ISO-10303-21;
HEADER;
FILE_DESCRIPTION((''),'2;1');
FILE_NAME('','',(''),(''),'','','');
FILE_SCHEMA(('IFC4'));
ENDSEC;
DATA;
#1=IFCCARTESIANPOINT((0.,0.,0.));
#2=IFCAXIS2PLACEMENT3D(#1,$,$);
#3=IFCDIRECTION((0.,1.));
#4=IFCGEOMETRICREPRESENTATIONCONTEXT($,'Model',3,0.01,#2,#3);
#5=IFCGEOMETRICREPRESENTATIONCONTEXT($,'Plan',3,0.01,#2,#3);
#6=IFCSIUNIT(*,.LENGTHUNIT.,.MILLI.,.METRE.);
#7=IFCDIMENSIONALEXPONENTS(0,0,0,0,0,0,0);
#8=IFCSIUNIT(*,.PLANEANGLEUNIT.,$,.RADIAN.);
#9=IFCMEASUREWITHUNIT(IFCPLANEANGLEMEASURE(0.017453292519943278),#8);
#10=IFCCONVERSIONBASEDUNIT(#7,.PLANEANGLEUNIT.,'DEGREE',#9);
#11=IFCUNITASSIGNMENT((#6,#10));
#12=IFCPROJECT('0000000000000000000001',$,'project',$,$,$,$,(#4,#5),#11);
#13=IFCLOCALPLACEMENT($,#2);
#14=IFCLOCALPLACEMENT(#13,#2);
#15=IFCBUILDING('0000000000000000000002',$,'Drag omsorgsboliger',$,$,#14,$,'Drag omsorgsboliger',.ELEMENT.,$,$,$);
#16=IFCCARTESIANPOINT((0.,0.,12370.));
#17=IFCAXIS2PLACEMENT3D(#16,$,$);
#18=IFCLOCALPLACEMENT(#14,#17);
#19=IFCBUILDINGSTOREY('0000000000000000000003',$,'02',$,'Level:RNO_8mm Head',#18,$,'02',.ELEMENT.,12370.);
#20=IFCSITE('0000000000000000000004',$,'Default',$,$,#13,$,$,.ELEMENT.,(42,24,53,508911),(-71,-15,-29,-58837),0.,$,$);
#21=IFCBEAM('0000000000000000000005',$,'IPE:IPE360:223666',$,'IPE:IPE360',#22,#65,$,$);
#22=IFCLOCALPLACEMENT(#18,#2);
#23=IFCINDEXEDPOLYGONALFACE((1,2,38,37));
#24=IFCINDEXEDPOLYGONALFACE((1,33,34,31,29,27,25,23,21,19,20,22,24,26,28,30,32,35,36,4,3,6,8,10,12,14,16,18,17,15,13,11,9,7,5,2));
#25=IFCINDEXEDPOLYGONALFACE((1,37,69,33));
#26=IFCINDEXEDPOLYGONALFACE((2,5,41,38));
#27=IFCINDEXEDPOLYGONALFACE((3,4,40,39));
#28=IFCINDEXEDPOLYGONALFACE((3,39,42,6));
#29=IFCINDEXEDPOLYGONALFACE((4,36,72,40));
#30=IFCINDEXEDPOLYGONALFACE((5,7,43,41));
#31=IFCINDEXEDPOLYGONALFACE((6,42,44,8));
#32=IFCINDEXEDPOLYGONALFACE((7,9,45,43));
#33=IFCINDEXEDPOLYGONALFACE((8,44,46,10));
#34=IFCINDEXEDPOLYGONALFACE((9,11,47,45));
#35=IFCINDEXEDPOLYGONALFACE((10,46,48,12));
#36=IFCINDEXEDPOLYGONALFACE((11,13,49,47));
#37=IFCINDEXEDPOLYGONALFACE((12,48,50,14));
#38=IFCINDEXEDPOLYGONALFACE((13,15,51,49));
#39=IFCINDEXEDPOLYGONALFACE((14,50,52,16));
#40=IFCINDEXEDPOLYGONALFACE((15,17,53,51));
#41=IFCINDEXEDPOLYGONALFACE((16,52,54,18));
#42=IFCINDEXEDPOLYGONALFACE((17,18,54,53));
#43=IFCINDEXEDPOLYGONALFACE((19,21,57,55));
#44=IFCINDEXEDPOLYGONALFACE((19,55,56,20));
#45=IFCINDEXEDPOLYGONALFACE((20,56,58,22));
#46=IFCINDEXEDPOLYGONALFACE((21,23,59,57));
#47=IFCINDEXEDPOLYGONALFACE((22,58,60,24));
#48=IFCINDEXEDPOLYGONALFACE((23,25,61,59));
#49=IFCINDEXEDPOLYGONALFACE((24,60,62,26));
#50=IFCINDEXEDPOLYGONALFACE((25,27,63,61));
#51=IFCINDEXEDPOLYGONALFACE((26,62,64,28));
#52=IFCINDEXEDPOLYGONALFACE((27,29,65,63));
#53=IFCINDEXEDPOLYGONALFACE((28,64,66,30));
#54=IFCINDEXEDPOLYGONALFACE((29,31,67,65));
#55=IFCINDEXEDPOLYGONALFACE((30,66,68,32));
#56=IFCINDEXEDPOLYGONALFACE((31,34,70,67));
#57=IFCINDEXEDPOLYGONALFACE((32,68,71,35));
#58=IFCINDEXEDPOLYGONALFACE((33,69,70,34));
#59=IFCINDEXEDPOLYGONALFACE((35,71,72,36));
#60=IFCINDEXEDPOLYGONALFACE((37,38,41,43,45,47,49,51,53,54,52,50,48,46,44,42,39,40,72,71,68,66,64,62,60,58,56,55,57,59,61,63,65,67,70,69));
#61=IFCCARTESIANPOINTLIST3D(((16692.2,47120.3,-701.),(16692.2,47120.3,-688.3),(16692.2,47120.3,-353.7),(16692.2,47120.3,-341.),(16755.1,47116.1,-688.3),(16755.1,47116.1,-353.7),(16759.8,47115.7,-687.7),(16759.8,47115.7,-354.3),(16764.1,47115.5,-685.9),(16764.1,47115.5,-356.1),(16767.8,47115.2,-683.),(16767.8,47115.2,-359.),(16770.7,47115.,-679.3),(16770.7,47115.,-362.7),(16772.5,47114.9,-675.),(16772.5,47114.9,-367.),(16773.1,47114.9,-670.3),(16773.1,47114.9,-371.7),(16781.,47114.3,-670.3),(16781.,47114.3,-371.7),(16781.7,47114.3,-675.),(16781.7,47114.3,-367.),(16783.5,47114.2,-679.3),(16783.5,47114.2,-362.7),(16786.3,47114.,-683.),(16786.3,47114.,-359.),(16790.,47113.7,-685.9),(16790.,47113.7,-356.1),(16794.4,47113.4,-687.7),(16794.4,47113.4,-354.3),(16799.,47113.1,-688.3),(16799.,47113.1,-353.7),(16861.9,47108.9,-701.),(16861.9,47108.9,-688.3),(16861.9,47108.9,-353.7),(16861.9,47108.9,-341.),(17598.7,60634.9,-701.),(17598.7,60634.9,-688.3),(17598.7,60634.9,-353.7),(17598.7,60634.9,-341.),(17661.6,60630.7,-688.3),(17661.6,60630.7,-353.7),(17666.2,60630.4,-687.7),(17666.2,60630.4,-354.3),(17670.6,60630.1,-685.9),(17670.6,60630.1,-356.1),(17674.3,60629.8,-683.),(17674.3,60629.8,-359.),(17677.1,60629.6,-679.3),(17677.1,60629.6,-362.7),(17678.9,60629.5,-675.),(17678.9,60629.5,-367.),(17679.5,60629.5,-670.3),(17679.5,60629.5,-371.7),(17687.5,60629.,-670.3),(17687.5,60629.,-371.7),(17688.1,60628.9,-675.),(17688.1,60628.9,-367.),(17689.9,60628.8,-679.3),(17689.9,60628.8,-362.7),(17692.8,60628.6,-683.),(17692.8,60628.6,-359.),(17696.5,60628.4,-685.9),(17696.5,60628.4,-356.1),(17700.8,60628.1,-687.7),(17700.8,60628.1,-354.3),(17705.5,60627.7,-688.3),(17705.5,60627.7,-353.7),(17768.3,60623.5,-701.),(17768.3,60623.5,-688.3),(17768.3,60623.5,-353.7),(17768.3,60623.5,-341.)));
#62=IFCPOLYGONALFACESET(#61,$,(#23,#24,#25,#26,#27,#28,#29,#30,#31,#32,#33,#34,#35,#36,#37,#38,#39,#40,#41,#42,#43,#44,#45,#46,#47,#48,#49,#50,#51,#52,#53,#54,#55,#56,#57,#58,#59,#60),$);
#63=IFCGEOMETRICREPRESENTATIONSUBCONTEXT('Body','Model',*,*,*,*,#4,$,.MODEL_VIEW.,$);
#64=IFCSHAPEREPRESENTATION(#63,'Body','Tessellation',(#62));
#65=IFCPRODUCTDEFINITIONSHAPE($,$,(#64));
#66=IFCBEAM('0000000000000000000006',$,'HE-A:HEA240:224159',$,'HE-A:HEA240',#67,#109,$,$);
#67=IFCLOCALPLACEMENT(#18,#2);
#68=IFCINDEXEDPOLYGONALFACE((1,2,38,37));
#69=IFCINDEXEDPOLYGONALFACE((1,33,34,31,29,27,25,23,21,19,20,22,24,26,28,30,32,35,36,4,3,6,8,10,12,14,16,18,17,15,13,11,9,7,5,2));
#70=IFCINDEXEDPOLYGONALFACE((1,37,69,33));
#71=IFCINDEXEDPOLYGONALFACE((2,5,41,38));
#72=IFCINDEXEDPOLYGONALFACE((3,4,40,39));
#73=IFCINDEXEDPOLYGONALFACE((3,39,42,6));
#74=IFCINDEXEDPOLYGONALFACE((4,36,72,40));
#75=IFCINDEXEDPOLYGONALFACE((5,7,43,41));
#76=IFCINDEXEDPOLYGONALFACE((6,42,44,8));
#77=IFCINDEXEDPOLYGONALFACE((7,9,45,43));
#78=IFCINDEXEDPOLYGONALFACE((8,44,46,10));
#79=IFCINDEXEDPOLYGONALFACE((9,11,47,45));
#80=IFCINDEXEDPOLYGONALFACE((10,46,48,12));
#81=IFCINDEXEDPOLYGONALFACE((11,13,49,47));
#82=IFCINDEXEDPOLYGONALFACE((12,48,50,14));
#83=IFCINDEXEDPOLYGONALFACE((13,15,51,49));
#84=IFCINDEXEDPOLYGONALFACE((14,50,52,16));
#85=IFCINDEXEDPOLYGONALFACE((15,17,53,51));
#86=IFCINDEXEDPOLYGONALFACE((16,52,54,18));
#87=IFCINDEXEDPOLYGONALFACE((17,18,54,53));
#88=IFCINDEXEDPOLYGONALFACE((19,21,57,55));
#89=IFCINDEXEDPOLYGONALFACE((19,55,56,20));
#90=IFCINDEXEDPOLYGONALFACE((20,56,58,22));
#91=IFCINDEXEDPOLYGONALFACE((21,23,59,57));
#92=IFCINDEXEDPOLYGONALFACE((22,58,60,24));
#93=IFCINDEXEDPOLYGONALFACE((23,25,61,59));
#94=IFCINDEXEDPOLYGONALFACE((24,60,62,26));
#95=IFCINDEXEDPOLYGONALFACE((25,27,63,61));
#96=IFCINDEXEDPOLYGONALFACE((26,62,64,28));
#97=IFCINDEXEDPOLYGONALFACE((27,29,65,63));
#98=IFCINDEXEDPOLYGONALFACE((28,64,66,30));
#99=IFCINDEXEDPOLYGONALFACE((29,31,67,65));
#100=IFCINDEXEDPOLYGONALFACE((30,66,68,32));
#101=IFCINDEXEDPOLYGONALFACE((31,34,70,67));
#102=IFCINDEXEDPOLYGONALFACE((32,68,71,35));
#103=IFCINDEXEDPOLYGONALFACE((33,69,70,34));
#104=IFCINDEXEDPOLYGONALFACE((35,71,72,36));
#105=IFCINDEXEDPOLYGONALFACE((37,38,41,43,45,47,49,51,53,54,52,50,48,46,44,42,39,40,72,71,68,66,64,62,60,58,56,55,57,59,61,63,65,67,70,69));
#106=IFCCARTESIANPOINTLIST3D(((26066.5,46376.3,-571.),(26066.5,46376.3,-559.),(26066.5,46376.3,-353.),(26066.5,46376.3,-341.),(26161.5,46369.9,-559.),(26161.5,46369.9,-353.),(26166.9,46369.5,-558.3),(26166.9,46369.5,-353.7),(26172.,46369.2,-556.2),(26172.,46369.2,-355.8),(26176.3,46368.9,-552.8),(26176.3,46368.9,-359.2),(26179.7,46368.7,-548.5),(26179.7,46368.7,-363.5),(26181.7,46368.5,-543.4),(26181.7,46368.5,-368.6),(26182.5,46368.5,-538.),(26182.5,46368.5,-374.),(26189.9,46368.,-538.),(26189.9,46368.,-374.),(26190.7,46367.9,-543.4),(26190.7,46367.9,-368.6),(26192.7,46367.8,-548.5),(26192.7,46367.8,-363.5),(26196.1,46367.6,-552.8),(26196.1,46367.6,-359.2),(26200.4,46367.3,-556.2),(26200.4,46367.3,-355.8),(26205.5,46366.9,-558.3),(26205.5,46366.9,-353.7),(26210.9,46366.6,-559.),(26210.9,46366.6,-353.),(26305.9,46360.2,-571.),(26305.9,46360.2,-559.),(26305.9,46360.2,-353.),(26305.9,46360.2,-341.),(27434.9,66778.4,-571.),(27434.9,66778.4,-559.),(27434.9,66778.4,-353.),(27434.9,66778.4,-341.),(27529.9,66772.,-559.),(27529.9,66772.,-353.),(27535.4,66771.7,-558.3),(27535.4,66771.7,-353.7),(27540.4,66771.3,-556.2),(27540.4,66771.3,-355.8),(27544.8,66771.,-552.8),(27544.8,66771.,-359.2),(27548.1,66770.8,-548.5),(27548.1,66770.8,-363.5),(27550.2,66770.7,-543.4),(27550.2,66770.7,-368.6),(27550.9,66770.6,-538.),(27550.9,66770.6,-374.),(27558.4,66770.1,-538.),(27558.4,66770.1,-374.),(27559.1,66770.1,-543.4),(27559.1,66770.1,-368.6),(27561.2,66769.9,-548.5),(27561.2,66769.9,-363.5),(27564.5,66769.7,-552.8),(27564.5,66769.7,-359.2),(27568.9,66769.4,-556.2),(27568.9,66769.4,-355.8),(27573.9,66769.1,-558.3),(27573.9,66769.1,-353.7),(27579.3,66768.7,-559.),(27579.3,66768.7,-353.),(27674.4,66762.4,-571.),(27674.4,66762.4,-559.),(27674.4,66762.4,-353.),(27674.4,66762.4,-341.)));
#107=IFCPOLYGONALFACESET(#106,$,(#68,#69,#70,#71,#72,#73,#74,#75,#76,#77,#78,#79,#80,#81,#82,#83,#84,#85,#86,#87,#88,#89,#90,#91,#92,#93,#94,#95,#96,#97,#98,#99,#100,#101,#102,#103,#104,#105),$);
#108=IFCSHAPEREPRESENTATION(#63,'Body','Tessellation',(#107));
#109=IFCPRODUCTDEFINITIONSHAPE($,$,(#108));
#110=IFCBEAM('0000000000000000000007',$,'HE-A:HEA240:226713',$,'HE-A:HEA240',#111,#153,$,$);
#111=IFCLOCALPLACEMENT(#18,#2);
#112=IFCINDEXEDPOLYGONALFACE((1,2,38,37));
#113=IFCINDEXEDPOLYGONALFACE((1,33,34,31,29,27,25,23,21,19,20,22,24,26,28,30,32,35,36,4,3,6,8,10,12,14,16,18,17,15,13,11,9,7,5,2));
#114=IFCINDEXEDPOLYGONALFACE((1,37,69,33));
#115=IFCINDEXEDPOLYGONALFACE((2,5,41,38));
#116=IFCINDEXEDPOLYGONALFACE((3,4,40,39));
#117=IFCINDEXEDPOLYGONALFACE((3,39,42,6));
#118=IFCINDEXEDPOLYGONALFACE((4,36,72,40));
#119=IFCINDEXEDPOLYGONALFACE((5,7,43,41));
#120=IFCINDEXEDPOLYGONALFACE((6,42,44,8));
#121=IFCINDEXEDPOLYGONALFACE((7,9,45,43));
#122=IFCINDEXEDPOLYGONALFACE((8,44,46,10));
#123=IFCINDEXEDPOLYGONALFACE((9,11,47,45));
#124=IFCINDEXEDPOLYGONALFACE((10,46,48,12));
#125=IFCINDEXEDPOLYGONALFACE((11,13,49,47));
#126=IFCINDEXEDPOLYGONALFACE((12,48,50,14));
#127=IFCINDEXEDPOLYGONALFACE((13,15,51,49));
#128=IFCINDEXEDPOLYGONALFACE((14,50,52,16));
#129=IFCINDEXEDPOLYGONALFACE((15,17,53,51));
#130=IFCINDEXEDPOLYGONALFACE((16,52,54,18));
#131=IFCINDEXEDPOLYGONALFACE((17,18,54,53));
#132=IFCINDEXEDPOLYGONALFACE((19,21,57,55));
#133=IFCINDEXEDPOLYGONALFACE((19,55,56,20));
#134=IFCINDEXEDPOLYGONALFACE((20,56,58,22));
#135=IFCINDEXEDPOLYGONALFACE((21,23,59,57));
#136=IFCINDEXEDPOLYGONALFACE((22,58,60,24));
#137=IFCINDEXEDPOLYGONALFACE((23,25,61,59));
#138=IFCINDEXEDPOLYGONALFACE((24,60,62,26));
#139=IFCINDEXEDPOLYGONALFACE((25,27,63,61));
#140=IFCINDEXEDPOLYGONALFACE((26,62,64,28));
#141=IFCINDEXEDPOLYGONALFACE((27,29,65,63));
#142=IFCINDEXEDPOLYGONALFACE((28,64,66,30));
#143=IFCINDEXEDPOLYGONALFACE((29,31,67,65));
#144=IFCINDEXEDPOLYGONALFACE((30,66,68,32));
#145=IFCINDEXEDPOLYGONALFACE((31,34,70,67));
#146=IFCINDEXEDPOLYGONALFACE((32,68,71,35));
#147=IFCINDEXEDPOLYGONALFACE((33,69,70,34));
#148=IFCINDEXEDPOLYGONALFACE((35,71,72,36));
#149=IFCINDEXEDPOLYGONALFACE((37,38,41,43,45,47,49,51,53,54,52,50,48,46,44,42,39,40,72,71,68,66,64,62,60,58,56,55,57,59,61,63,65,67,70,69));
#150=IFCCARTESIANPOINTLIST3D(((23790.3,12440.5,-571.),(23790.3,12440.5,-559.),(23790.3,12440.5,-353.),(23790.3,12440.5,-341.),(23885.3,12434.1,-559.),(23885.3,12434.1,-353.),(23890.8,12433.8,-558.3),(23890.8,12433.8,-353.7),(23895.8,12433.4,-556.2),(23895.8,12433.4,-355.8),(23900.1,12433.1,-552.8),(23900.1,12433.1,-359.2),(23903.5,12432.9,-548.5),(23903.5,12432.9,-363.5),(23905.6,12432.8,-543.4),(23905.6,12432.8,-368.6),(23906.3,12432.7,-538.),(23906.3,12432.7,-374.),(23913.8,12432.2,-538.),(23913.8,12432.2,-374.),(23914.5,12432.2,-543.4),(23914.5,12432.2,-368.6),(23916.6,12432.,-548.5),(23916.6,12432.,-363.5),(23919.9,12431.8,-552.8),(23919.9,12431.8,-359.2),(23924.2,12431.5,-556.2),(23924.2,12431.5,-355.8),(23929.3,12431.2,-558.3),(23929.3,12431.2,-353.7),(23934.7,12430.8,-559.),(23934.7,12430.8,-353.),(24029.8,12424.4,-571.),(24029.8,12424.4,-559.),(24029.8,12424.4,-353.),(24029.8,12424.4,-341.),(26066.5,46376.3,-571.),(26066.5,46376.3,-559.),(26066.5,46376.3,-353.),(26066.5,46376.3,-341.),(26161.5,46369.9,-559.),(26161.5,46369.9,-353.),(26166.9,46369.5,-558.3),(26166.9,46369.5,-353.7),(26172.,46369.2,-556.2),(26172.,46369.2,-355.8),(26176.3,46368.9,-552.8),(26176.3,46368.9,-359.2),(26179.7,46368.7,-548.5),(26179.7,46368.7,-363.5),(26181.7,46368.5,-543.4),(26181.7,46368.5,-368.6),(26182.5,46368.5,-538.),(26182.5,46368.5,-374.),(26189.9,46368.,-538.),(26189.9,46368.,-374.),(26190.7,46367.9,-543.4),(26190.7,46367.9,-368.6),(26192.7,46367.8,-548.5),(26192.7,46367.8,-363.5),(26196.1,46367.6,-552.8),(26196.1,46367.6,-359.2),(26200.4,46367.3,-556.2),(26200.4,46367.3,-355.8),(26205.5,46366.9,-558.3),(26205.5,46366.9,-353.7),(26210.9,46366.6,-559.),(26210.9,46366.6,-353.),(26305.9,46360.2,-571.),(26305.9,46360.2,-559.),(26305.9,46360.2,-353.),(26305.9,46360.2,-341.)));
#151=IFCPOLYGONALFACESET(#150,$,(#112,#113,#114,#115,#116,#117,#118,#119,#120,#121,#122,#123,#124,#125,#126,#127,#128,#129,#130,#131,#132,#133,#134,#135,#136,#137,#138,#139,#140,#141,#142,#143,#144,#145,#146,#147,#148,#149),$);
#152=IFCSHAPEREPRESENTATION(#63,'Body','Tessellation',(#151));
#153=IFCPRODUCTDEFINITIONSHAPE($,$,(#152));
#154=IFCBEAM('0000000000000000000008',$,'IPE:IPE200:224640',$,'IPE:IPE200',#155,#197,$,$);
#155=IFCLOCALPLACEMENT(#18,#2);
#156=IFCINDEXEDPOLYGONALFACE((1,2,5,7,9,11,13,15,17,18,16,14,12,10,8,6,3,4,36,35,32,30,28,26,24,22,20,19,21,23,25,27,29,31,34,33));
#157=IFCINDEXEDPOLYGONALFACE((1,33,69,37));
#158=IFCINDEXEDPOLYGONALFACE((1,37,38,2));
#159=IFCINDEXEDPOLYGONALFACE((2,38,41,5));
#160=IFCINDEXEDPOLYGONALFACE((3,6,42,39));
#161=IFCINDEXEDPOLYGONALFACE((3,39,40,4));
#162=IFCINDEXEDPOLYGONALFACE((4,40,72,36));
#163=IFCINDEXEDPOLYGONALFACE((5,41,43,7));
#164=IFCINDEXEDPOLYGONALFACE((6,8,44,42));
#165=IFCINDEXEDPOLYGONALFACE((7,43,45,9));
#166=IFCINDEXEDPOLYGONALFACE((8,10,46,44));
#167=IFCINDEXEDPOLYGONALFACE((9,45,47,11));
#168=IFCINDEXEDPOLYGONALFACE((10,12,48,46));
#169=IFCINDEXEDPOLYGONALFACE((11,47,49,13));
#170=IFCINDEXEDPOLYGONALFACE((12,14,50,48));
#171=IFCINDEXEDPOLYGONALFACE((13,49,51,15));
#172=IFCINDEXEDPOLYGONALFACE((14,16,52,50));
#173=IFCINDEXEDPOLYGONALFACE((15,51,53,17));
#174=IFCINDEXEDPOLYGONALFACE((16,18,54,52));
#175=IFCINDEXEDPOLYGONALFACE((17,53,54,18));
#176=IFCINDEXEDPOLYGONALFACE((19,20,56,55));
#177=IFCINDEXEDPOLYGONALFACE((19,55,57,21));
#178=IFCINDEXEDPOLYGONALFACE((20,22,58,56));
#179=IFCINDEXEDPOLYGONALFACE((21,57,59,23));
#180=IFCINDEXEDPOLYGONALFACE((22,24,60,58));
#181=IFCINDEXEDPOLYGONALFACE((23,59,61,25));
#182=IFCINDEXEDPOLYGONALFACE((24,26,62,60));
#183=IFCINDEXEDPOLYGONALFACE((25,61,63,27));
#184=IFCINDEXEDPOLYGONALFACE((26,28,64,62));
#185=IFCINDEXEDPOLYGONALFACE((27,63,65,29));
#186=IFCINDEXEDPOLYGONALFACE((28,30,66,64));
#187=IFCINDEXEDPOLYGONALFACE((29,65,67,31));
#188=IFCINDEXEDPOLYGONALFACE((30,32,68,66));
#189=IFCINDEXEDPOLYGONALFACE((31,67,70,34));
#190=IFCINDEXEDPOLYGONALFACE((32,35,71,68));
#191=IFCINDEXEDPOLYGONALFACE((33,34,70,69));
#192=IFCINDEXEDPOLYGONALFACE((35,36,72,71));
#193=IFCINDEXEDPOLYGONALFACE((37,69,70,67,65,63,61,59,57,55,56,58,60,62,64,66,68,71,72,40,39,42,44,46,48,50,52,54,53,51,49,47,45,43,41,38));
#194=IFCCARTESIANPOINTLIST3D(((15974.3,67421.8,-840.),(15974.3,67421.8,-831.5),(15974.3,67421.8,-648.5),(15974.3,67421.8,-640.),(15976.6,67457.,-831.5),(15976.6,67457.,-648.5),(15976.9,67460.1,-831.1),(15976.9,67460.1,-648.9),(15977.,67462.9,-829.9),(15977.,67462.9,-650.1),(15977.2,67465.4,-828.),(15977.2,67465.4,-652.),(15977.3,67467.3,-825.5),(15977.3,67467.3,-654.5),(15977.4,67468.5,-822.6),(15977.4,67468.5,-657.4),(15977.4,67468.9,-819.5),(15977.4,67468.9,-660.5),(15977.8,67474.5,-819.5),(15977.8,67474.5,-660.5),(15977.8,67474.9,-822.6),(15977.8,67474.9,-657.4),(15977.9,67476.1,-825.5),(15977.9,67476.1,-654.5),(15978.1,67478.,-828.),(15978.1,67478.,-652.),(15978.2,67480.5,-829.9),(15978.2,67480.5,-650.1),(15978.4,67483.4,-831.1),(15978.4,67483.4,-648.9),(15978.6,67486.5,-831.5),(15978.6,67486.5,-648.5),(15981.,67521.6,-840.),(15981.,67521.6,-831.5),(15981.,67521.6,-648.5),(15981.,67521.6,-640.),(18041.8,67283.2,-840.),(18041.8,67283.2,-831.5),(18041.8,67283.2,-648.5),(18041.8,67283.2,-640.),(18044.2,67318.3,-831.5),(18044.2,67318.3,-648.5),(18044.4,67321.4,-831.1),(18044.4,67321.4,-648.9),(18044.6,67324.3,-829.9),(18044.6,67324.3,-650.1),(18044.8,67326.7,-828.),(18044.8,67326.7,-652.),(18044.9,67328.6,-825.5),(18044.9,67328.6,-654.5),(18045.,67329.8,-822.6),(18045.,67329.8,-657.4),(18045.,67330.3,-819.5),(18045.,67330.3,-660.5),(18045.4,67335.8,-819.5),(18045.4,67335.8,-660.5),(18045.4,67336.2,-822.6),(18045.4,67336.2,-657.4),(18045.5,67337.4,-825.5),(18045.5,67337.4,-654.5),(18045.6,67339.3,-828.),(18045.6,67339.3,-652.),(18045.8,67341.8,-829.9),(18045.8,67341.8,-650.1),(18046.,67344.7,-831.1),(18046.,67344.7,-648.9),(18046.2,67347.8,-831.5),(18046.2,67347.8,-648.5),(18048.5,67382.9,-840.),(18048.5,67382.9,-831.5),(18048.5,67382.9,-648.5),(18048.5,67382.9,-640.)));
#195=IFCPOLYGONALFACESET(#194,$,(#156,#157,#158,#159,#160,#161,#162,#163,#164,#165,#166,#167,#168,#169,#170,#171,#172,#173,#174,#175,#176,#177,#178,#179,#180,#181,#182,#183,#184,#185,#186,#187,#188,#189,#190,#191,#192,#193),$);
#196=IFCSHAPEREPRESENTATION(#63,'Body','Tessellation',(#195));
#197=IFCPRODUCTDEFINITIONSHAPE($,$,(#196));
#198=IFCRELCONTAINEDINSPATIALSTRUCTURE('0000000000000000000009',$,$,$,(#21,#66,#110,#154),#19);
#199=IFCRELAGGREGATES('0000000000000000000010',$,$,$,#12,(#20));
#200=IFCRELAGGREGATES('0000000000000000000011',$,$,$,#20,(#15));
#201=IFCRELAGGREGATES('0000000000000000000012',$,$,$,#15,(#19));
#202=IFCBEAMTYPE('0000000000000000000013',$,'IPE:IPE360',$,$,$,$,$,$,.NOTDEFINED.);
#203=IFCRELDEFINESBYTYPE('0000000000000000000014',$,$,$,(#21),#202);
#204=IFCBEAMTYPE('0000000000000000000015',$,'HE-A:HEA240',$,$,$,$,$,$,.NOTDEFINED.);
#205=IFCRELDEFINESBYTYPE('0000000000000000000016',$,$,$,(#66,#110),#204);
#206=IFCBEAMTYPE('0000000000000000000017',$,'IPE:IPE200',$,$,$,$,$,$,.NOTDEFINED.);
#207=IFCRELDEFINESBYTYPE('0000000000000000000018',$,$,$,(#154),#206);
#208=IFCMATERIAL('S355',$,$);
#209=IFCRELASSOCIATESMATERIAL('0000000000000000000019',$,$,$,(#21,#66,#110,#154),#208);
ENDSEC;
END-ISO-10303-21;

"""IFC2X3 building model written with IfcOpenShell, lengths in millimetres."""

from ifc_helpers import new_model, entity, si_unit, converted_unit, direction, frame, frame_2d, origin, place, context, subcontext, project, spatial, i_section, extrude, material, type_object, element, save


model = new_model("IFC2X3")

# Units and contexts
model_context = context("Model", 3, precision=0.01, world=origin(), true_north=direction((0.0, 1.0)))
plan_context = context("Plan", 3, precision=0.01, world=origin(), true_north=direction((0.0, 1.0)))
body_context = subcontext(model_context, "Body", "Model", "MODEL_VIEW")
ifc_project = project(units=[si_unit("LENGTHUNIT", "METRE", prefix="MILLI"), converted_unit("PLANEANGLEUNIT", "DEGREE", entity("IfcPlaneAngleMeasure", 0.017453292519943278), si_unit("PLANEANGLEUNIT", "RADIAN"), dimensions=[0, 0, 0, 0, 0, 0, 0])], contexts=[model_context, plan_context])

# Site, building, storey
site_placement = place(None, origin())
site = spatial("IfcSite", under=ifc_project, at=site_placement, Name="Default", CompositionType="ELEMENT", RefLatitude=(42, 24, 53, 508911), RefLongitude=(-71, -15, -29, -58837), RefElevation=0.0)
building_placement = place(site_placement, origin())
building = spatial("IfcBuilding", under=site, at=building_placement, Name="Drag omsorgsboliger", LongName="Drag omsorgsboliger", CompositionType="ELEMENT")
storey_placement = place(building_placement, frame((0.0, 0.0, 12370.0)))
storey = spatial("IfcBuildingStorey", under=building, at=storey_placement, Name="02", ObjectType="Level:RNO_8mm Head", LongName="02", CompositionType="ELEMENT", Elevation=12370.0)

# Beams
ifc_material_1 = material(Name="S355")
beam_type_1 = type_object("IfcBeamType", Name="IPE:IPE360", PredefinedType="NOTDEFINED")
beam_1_placement = place(storey_placement, frame((17683.5, 60629.2, -341.0), z_axis=(0.0, 0.0, 1.0), x_axis=(-0.066923, -0.997758, 0.0)))
element("IfcBeam", 1, at=beam_1_placement, inside=storey, type_object=beam_type_1, material=ifc_material_1, Name="IPE:IPE360:223666", ObjectType="IPE:IPE360", context=body_context, shape_type="SweptSolid", body=[
    extrude(i_section(OverallWidth=170.0, OverallDepth=360.0, WebThickness=8.0, FlangeThickness=12.7, FilletRadius=18.0, at=frame_2d((0.0, 0.0), x_axis=(0.0, 1.0))), frame((0.0, 0.0, -180.0), z_axis=(1.0, 0.0, 0.0), x_axis=(0.0, 0.0, -1.0)), (0.0, 0.0, 1.0), 13545.0),
])
beam_type_2 = type_object("IfcBeamType", Name="HE-A:HEA240", PredefinedType="NOTDEFINED")
beam_2_placement = place(storey_placement, frame((27554.6, 66770.4, -341.0), z_axis=(0.0, 0.0, 1.0), x_axis=(-0.066923, -0.997758, 0.0)))
element("IfcBeam", 2, at=beam_2_placement, inside=storey, type_object=beam_type_2, material=ifc_material_1, Name="HE-A:HEA240:224159", ObjectType="HE-A:HEA240", context=body_context, shape_type="SweptSolid", body=[
    extrude(i_section(OverallWidth=240.0, OverallDepth=230.0, WebThickness=7.5, FlangeThickness=12.0, FilletRadius=21.0, at=frame_2d((0.0, 0.0), x_axis=(0.0, 1.0))), frame((0.0, 0.0, -115.0), z_axis=(1.0, 0.0, 0.0), x_axis=(0.0, 0.0, -1.0)), (0.0, 0.0, 1.0), 20448.0),
])
beam_3_placement = place(storey_placement, frame((26186.2, 46368.2, -341.0), z_axis=(0.0, 0.0, 1.0), x_axis=(-0.066923, -0.997758, 0.0)))
element("IfcBeam", 3, at=beam_3_placement, inside=storey, type_object=beam_type_2, material=ifc_material_1, Name="HE-A:HEA240:226713", ObjectType="HE-A:HEA240", context=body_context, shape_type="SweptSolid", body=[
    extrude(i_section(OverallWidth=240.0, OverallDepth=230.0, WebThickness=7.5, FlangeThickness=12.0, FilletRadius=21.0, at=frame_2d((0.0, 0.0), x_axis=(0.0, 1.0))), frame((0.0, 0.0, -115.0), z_axis=(1.0, 0.0, 0.0), x_axis=(0.0, 0.0, -1.0)), (0.0, 0.0, 1.0), 34012.0),
])
beam_type_3 = type_object("IfcBeamType", Name="IPE:IPE200", PredefinedType="NOTDEFINED")
beam_4_placement = place(storey_placement, frame((18072.9, 67331.2, -640.0), z_axis=(0.0, 0.0, 1.0), x_axis=(-0.997758, 0.066923, 0.0)))
element("IfcBeam", 4, at=beam_4_placement, inside=storey, type_object=beam_type_3, material=ifc_material_1, Name="IPE:IPE200:224640", ObjectType="IPE:IPE200", context=body_context, shape_type="SweptSolid", body=[
    extrude(i_section(OverallWidth=100.0, OverallDepth=200.0, WebThickness=5.6, FlangeThickness=8.5, FilletRadius=12.0, at=frame_2d((0.0, 0.0), x_axis=(0.0, 1.0))), frame((27.8, 0.0, -100.0), z_axis=(1.0, 0.0, 0.0), x_axis=(0.0, 0.0, -1.0)), (0.0, 0.0, 1.0), 2072.2),
])

save(model, "model.ifc")
